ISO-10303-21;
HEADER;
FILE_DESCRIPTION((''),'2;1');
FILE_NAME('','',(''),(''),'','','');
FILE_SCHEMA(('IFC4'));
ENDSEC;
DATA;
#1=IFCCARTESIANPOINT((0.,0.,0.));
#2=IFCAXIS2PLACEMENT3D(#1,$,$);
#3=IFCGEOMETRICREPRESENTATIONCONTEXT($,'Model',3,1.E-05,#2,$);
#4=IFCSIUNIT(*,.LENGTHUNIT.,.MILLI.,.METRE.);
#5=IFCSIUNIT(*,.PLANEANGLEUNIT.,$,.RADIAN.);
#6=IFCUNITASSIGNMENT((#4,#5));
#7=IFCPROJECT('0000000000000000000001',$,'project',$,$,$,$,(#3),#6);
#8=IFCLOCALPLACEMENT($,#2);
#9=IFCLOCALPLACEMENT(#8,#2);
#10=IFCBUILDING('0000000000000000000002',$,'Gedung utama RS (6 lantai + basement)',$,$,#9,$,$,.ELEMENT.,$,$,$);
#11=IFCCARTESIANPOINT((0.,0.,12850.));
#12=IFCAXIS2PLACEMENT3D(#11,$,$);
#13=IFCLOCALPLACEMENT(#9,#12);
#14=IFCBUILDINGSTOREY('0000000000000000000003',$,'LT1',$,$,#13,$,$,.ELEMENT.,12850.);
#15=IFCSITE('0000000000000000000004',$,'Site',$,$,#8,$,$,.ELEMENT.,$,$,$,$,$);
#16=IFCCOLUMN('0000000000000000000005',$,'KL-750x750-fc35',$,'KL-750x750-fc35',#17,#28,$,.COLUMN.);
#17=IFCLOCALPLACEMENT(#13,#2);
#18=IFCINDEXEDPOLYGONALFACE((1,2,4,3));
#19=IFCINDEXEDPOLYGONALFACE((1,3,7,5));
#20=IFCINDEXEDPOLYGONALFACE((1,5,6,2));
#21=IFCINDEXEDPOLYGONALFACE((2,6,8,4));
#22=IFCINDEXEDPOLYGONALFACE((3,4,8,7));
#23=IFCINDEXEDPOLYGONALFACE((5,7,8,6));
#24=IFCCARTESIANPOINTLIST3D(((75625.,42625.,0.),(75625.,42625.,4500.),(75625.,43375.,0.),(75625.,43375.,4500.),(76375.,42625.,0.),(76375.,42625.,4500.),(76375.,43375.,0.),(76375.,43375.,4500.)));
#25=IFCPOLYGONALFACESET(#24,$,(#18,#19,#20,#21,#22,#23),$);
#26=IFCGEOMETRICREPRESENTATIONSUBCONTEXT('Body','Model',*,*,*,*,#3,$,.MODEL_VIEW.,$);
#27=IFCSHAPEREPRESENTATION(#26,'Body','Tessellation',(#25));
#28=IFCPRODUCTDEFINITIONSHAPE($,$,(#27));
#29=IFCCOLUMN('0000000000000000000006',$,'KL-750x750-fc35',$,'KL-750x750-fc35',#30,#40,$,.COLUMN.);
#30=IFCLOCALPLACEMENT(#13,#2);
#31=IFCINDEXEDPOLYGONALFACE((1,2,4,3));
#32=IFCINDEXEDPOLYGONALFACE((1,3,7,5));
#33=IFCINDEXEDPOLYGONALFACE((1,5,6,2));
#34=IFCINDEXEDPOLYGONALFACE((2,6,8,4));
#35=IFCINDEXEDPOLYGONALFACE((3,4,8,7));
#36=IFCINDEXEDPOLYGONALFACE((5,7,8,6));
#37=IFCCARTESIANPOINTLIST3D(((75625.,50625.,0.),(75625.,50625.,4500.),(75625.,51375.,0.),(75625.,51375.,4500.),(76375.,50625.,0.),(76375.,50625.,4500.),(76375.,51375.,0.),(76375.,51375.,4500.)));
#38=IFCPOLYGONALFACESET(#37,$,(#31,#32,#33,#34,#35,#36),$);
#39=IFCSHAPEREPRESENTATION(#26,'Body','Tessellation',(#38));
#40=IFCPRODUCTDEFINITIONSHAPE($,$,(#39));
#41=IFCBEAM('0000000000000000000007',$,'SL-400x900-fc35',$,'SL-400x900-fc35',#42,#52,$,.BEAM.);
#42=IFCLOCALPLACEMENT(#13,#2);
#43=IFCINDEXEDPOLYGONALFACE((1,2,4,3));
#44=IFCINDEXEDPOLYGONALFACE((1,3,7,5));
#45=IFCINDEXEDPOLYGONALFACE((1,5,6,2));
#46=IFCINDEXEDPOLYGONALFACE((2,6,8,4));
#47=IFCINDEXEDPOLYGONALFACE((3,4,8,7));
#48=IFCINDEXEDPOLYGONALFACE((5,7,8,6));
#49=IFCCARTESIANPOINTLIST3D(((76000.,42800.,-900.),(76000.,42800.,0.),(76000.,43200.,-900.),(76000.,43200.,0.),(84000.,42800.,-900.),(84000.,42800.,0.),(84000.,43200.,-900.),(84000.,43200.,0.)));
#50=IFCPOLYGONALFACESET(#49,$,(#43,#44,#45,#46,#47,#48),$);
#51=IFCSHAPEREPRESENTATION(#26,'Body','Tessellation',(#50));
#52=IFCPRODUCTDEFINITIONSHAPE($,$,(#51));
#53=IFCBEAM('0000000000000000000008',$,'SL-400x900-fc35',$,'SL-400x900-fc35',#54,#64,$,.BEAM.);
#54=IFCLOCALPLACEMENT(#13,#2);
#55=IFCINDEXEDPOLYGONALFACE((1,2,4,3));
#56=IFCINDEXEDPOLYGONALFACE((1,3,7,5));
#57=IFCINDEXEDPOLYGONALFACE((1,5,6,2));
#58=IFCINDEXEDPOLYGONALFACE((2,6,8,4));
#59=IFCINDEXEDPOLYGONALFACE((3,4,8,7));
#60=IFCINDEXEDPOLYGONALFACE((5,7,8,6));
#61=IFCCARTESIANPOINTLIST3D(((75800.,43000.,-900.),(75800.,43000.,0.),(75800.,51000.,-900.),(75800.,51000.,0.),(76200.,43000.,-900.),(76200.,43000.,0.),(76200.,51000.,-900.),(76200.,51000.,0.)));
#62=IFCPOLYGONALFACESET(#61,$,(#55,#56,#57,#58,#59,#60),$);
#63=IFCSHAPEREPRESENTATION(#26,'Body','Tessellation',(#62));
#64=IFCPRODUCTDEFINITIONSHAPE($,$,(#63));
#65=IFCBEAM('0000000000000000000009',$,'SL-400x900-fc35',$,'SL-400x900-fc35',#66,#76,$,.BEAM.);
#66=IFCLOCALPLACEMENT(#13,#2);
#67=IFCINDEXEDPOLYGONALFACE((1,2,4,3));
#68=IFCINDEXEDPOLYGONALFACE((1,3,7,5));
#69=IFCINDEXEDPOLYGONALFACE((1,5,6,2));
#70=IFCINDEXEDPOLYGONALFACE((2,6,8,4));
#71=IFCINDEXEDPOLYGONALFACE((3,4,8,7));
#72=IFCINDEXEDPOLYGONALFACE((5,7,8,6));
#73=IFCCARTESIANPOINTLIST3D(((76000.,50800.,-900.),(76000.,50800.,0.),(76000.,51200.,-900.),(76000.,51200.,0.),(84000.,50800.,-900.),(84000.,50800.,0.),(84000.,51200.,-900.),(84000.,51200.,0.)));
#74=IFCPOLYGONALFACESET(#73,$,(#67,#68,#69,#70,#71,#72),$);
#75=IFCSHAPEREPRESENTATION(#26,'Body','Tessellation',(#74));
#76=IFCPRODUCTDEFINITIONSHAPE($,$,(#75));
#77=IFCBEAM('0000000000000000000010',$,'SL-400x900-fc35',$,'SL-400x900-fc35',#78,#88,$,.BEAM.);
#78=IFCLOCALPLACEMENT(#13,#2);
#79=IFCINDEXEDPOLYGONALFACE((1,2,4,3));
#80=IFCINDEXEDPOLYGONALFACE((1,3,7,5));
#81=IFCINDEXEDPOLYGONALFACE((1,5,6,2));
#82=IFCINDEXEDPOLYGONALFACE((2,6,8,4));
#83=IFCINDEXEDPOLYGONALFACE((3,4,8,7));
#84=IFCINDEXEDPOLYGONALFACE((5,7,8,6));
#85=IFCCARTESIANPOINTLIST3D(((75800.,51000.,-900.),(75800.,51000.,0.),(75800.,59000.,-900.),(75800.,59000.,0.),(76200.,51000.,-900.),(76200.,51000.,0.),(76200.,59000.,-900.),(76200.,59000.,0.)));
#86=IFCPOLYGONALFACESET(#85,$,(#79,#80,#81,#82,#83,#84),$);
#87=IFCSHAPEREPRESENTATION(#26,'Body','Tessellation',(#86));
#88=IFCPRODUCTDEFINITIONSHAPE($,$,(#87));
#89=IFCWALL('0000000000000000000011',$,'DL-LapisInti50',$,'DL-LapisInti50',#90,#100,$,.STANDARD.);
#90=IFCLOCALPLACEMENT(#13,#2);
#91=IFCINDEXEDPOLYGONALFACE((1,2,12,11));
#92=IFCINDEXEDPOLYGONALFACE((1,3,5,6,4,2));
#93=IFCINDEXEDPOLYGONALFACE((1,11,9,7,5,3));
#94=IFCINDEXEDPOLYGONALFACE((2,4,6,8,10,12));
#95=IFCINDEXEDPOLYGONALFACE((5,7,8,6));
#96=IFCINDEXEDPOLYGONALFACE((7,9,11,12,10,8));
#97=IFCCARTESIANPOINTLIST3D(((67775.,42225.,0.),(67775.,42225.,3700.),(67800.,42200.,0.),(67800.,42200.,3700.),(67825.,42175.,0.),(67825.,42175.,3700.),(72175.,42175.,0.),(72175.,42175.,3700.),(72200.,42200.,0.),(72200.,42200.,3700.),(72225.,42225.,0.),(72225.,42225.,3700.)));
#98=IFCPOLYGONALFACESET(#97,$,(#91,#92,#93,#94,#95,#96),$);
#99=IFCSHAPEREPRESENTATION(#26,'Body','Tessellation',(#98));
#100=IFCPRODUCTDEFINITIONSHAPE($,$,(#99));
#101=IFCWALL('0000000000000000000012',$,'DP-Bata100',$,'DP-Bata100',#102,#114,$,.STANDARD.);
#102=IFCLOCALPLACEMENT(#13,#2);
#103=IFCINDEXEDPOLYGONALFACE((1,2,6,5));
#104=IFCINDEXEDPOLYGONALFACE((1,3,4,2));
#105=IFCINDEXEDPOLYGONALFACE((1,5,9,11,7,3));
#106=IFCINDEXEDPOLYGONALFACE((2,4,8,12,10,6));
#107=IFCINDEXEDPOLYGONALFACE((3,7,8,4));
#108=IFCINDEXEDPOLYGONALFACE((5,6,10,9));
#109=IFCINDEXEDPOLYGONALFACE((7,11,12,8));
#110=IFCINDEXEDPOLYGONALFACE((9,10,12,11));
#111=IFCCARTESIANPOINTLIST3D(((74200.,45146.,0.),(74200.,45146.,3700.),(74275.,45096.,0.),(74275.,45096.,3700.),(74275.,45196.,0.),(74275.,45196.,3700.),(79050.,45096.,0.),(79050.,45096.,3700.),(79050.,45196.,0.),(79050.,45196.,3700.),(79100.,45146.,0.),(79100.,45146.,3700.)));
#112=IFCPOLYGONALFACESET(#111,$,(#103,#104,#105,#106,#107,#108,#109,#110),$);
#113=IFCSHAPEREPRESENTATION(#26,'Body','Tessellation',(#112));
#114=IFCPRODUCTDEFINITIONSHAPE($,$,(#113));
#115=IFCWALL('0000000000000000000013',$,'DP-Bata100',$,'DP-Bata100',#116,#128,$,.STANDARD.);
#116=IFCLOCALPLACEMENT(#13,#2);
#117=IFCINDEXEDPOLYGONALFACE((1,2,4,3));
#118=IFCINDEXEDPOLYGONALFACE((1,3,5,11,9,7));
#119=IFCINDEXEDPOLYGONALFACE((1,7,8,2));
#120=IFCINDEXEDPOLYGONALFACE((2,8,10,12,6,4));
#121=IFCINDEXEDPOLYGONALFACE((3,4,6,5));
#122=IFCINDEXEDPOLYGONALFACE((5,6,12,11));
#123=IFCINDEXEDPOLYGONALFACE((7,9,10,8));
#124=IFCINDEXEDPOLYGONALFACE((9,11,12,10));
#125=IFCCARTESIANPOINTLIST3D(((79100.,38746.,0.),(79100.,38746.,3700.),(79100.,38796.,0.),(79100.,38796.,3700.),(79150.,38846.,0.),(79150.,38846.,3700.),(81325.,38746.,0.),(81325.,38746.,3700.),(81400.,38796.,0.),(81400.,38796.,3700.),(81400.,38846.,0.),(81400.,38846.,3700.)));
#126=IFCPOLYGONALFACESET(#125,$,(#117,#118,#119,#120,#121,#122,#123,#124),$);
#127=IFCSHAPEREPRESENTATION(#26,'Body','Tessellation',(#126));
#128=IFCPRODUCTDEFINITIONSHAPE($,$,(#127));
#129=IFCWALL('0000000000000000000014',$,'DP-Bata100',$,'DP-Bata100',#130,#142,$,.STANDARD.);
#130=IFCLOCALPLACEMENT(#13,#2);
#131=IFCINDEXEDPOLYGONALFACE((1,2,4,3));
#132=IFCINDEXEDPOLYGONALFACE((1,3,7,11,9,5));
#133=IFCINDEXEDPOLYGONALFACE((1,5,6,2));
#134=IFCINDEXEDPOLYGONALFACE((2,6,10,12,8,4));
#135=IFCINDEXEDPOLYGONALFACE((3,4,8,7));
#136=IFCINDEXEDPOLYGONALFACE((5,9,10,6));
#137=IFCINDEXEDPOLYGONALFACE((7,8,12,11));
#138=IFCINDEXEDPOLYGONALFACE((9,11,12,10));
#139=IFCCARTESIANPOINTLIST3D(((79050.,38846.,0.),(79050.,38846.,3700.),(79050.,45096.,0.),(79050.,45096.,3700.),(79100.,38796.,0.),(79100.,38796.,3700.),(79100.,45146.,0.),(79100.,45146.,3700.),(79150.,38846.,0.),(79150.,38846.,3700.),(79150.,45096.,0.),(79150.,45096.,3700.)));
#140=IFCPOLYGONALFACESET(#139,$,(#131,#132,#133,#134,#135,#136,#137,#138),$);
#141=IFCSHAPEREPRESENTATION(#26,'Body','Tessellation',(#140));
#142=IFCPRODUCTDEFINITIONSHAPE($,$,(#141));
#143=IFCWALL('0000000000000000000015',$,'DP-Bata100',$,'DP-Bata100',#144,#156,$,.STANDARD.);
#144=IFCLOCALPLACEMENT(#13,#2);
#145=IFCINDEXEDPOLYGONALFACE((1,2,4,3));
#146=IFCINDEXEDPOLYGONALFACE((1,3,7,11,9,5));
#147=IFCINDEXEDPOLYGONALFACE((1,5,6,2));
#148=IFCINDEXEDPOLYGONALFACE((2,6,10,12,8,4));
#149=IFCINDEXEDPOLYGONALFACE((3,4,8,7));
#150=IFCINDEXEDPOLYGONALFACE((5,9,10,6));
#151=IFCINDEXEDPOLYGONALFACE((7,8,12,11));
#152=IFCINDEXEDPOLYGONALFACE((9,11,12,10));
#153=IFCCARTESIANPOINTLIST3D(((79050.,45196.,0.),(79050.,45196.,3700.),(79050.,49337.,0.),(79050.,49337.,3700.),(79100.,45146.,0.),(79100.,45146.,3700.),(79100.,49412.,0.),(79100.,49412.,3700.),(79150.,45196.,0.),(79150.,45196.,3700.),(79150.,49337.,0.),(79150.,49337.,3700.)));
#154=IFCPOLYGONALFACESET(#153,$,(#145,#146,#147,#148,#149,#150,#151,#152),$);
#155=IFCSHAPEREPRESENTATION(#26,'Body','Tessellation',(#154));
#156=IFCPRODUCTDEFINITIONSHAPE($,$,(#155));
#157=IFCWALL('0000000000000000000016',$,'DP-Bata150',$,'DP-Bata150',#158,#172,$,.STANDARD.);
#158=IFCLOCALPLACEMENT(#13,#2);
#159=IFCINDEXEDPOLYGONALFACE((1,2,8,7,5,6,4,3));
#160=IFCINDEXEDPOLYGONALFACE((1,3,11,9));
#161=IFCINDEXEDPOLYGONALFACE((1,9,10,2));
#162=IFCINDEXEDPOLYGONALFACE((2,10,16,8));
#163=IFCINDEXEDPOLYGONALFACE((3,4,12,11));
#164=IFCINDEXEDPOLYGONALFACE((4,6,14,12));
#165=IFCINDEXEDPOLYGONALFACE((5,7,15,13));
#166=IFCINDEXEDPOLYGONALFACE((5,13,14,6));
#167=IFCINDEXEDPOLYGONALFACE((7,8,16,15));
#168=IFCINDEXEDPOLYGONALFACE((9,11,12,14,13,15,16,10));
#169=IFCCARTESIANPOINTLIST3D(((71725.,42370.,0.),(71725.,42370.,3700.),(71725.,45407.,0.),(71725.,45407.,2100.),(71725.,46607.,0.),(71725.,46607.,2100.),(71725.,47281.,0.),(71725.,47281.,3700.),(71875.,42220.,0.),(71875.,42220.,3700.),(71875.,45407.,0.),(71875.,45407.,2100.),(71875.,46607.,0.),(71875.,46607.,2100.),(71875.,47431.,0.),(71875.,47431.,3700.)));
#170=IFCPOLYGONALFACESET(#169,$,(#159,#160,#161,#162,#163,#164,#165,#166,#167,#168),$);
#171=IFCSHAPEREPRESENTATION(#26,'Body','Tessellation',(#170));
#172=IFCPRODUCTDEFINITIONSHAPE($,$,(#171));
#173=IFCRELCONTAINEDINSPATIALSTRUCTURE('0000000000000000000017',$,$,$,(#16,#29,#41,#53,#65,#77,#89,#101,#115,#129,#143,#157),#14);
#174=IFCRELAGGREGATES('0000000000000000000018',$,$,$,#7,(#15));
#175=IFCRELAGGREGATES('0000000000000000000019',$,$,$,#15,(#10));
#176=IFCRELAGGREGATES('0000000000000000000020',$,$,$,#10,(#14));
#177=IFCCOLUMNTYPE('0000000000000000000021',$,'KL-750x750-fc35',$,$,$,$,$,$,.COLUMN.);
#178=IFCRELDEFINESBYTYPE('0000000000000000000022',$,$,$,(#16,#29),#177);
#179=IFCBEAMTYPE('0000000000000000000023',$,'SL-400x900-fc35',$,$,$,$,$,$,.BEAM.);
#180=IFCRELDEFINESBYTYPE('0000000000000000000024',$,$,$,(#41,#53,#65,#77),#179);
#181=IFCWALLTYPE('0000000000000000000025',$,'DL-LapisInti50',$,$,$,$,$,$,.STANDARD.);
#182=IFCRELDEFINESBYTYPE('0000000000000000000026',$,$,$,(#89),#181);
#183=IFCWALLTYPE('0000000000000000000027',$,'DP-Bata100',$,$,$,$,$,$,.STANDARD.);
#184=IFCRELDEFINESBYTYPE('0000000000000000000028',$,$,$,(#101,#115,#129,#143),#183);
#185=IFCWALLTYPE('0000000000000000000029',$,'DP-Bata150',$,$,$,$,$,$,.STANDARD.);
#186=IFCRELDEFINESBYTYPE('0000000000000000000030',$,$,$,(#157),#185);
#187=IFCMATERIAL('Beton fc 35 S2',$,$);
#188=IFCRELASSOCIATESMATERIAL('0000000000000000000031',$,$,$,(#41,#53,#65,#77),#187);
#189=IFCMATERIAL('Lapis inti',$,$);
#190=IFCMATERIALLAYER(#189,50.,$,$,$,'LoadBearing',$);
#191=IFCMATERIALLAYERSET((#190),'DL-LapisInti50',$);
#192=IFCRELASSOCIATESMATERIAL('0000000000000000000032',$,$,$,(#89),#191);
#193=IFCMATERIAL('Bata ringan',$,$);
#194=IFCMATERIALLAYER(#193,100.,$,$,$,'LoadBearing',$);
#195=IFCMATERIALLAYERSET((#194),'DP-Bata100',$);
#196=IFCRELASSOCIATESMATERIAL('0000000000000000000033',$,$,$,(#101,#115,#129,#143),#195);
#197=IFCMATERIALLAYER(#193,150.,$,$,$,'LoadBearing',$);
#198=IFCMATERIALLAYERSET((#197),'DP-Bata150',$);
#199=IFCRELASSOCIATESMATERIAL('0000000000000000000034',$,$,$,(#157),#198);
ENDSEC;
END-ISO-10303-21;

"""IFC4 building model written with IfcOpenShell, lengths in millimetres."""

from ifc_helpers import new_model, si_unit, frame, frame_2d, origin, origin_2d, place, context, subcontext, project, spatial, polyline, rectangle, outline, extrude, material, layer, layer_set, layer_usage, material_profile, profile_set, profile_usage, type_object, element, save


model = new_model("IFC4")

# Units and contexts
model_context = context("Model", 3, precision=1e-05, world=origin())
body_context = subcontext(model_context, "Body", "Model", "MODEL_VIEW")
ifc_project = project(units=[si_unit("LENGTHUNIT", "METRE", prefix="MILLI"), si_unit("PLANEANGLEUNIT", "RADIAN")], contexts=[model_context])

# Site, building, storey
site_placement = place(None, origin())
site = spatial("IfcSite", under=ifc_project, at=site_placement, Name="Site", CompositionType="ELEMENT")
building_placement = place(site_placement, origin())
building = spatial("IfcBuilding", under=site, at=building_placement, Name="Gedung utama RS (6 lantai + basement)", CompositionType="ELEMENT")
storey_placement = place(building_placement, frame((0.0, 0.0, 12850.0)))
storey = spatial("IfcBuildingStorey", under=building, at=storey_placement, Name="LT1", CompositionType="ELEMENT", Elevation=12850.0)

# Columns
ifc_material_profile_1 = material_profile(None, rectangle(XDim=750.0, YDim=750.0, at=origin_2d()), Name="KL-750x750-fc35")
ifc_profile_set_1 = profile_set([ifc_material_profile_1], Name="KL-750x750-fc35")
ifc_profile_usage_1 = profile_usage(ifc_profile_set_1, cardinal=5)
column_type = type_object("IfcColumnType", Name="KL-750x750-fc35", PredefinedType="COLUMN")
for number, where, z_axis, x_axis, name in (
    (1, (76000.0, 43000.0, 0.0), (0.0, 0.0, 1.0), (1.0, 0.0, 0.0), "KL-750x750-fc35"),
    (2, (76000.0, 51000.0, 0.0), (0.0, 0.0, 1.0), (1.0, 0.0, 0.0), "KL-750x750-fc35"),
):
    element("IfcColumn", number, at=place(storey_placement, frame(where, z_axis=z_axis, x_axis=x_axis)), inside=storey, type_object=column_type, material=ifc_profile_usage_1, Name=name, ObjectType="KL-750x750-fc35", PredefinedType="COLUMN", context=body_context, shape_type="SweptSolid", body=[
        extrude(rectangle(XDim=750.0, YDim=750.0, at=origin_2d()), origin(), (0.0, 0.0, 1.0), 4500.0),
    ])

# Beams
ifc_material_1 = material(Name="Beton fc 35 S2")
ifc_material_profile_2 = material_profile(ifc_material_1, rectangle(XDim=400.0, YDim=900.0, at=origin_2d()), Name="SL-400x900-fc35")
ifc_profile_set_2 = profile_set([ifc_material_profile_2], Name="SL-400x900-fc35")
ifc_profile_usage_2 = profile_usage(ifc_profile_set_2, cardinal=8)
beam_type = type_object("IfcBeamType", Name="SL-400x900-fc35", PredefinedType="BEAM")
beam_1_placement = place(storey_placement, frame((76000.0, 43000.0, -450.0)))
element("IfcBeam", 3, at=beam_1_placement, inside=storey, type_object=beam_type, material=ifc_profile_usage_2, Name="SL-400x900-fc35", ObjectType="SL-400x900-fc35", PredefinedType="BEAM", context=body_context, shape_type="SweptSolid", body=[
    extrude(rectangle(XDim=400.0, YDim=900.0, at=origin_2d()), frame((0.0, 0.0, 0.0), z_axis=(1.0, 0.0, 0.0), x_axis=(0.0, 1.0, 0.0)), (0.0, 0.0, 1.0), 8000.0),
])
beam_2_placement = place(storey_placement, frame((76000.0, 43000.0, -450.0)))
element("IfcBeam", 4, at=beam_2_placement, inside=storey, type_object=beam_type, material=ifc_profile_usage_2, Name="SL-400x900-fc35", ObjectType="SL-400x900-fc35", PredefinedType="BEAM", context=body_context, shape_type="SweptSolid", body=[
    extrude(rectangle(XDim=400.0, YDim=900.0, at=origin_2d()), frame((0.0, 0.0, 0.0), z_axis=(0.0, 1.0, 0.0), x_axis=(-1.0, 0.0, 0.0)), (0.0, 0.0, 1.0), 8000.0),
])
beam_3_placement = place(storey_placement, frame((76000.0, 51000.0, -450.0)))
element("IfcBeam", 5, at=beam_3_placement, inside=storey, type_object=beam_type, material=ifc_profile_usage_2, Name="SL-400x900-fc35", ObjectType="SL-400x900-fc35", PredefinedType="BEAM", context=body_context, shape_type="SweptSolid", body=[
    extrude(rectangle(XDim=400.0, YDim=900.0, at=origin_2d()), frame((0.0, 0.0, 0.0), z_axis=(1.0, 0.0, 0.0), x_axis=(0.0, 1.0, 0.0)), (0.0, 0.0, 1.0), 8000.0),
])
beam_4_placement = place(storey_placement, frame((76000.0, 51000.0, -450.0)))
element("IfcBeam", 6, at=beam_4_placement, inside=storey, type_object=beam_type, material=ifc_profile_usage_2, Name="SL-400x900-fc35", ObjectType="SL-400x900-fc35", PredefinedType="BEAM", context=body_context, shape_type="SweptSolid", body=[
    extrude(rectangle(XDim=400.0, YDim=900.0, at=origin_2d()), frame((0.0, 0.0, 0.0), z_axis=(0.0, 1.0, 0.0), x_axis=(-1.0, 0.0, 0.0)), (0.0, 0.0, 1.0), 8000.0),
])

# Walls
ifc_material_2 = material(Name="Lapis inti")
ifc_layer_1 = layer(ifc_material_2, 50.0, Category="LoadBearing")
ifc_layer_set_1 = layer_set([ifc_layer_1], Name="DL-LapisInti50")
ifc_layer_usage_1 = layer_usage(ifc_layer_set_1, "AXIS2", "NEGATIVE", 25.0)
wall_type_1 = type_object("IfcWallType", Name="DL-LapisInti50", PredefinedType="STANDARD")
wall_1_placement = place(storey_placement, frame((72200.0, 42200.0, 0.0), z_axis=(0.0, 0.0, 1.0), x_axis=(-1.0, 0.0, 0.0)))
element("IfcWall", 7, at=wall_1_placement, inside=storey, type_object=wall_type_1, material=ifc_layer_usage_1, Name="DL-LapisInti50", ObjectType="DL-LapisInti50", PredefinedType="STANDARD", context=body_context, shape_type="SweptSolid", body=[
    extrude(outline(polyline([(-25.0, -25.0), (0.0, 0.0), (25.0, 25.0), (4375.0, 25.0), (4400.0, 0.0), (4425.0, -25.0), (-25.0, -25.0)])), origin(), (0.0, 0.0, 1.0), 3700.0),
])
ifc_material_3 = material(Name="Bata ringan")
ifc_layer_2 = layer(ifc_material_3, 100.0, Category="LoadBearing")
ifc_layer_set_2 = layer_set([ifc_layer_2], Name="DP-Bata100")
ifc_layer_usage_2 = layer_usage(ifc_layer_set_2, "AXIS2", "NEGATIVE", 50.0)
wall_type_2 = type_object("IfcWallType", Name="DP-Bata100", PredefinedType="STANDARD")
wall_2_placement = place(storey_placement, frame((79100.0, 45146.0, 0.0), z_axis=(0.0, 0.0, 1.0), x_axis=(-1.0, 0.0, 0.0)))
element("IfcWall", 8, at=wall_2_placement, inside=storey, type_object=wall_type_2, material=ifc_layer_usage_2, Name="DP-Bata100", ObjectType="DP-Bata100", PredefinedType="STANDARD", context=body_context, shape_type="SweptSolid", body=[
    extrude(outline(polyline([(50.0, -50.0), (0.0, 0.0), (50.0, 50.0), (4825.0, 50.0), (4900.0, 0.0), (4825.0, -50.0), (50.0, -50.0)])), origin(), (0.0, 0.0, 1.0), 3700.0),
])
wall_3_placement = place(storey_placement, frame((81400.0, 38796.0, 0.0), z_axis=(0.0, 0.0, 1.0), x_axis=(-1.0, 0.0, 0.0)))
element("IfcWall", 9, at=wall_3_placement, inside=storey, type_object=wall_type_2, material=ifc_layer_usage_2, Name="DP-Bata100", ObjectType="DP-Bata100", PredefinedType="STANDARD", context=body_context, shape_type="SweptSolid", body=[
    extrude(outline(polyline([(0.0, -50.0), (0.0, 0.0), (75.0, 50.0), (2300.0, 50.0), (2300.0, 0.0), (2250.0, -50.0), (0.0, -50.0)])), origin(), (0.0, 0.0, 1.0), 3700.0),
])
wall_4_placement = place(storey_placement, frame((79100.0, 38796.0, 0.0), z_axis=(0.0, 0.0, 1.0), x_axis=(0.0, 1.0, 0.0)))
element("IfcWall", 10, at=wall_4_placement, inside=storey, type_object=wall_type_2, material=ifc_layer_usage_2, Name="DP-Bata100", ObjectType="DP-Bata100", PredefinedType="STANDARD", context=body_context, shape_type="SweptSolid", body=[
    extrude(outline(polyline([(50.0, -50.0), (0.0, 0.0), (50.0, 50.0), (6300.0, 50.0), (6350.0, 0.0), (6300.0, -50.0), (50.0, -50.0)])), origin(), (0.0, 0.0, 1.0), 3700.0),
])
wall_5_placement = place(storey_placement, frame((79100.0, 45146.0, 0.0), z_axis=(0.0, 0.0, 1.0), x_axis=(0.0, 1.0, 0.0)))
element("IfcWall", 11, at=wall_5_placement, inside=storey, type_object=wall_type_2, material=ifc_layer_usage_2, Name="DP-Bata100", ObjectType="DP-Bata100", PredefinedType="STANDARD", context=body_context, shape_type="SweptSolid", body=[
    extrude(outline(polyline([(50.0, -50.0), (0.0, 0.0), (50.0, 50.0), (4191.0, 50.0), (4266.0, 0.0), (4191.0, -50.0), (50.0, -50.0)])), origin(), (0.0, 0.0, 1.0), 3700.0),
])

# Wall, opening
ifc_layer_3 = layer(ifc_material_3, 150.0, Category="LoadBearing")
ifc_layer_set_3 = layer_set([ifc_layer_3], Name="DP-Bata150")
ifc_layer_usage_3 = layer_usage(ifc_layer_set_3, "AXIS2", "NEGATIVE", 75.0)
wall_type_3 = type_object("IfcWallType", Name="DP-Bata150", PredefinedType="STANDARD")
wall_6_placement = place(storey_placement, frame((71800.0, 47356.0, 0.0), z_axis=(0.0, 0.0, 1.0), x_axis=(0.0, -1.0, 0.0)))
wall_6 = element("IfcWall", 12, at=wall_6_placement, inside=storey, type_object=wall_type_3, material=ifc_layer_usage_3, Name="DP-Bata150", ObjectType="DP-Bata150", PredefinedType="STANDARD", context=body_context, shape_type="SweptSolid", body=[
    extrude(outline(polyline([(75.0, -75.0), (0.0, 0.0), (-75.0, 75.0), (5136.0, 75.0), (5061.0, 0.0), (4986.0, -75.0), (75.0, -75.0)])), origin(), (0.0, 0.0, 1.0), 3700.0),
])
opening_1_placement = place(wall_6_placement, frame((749.0, 0.0, 0.0), z_axis=(0.0, 0.0, 1.0), x_axis=(1.0, 0.0, 0.0)))
element("IfcOpeningElement", 13, at=opening_1_placement, cuts=wall_6, PredefinedType="OPENING", context=body_context, shape_type="SweptSolid", body=[
    extrude(rectangle(XDim=1200.0, YDim=170.0, at=frame_2d((600.0, 0.0))), origin(), (0.0, 0.0, 1.0), 2100.0),
])

save(model, "model.ifc")
